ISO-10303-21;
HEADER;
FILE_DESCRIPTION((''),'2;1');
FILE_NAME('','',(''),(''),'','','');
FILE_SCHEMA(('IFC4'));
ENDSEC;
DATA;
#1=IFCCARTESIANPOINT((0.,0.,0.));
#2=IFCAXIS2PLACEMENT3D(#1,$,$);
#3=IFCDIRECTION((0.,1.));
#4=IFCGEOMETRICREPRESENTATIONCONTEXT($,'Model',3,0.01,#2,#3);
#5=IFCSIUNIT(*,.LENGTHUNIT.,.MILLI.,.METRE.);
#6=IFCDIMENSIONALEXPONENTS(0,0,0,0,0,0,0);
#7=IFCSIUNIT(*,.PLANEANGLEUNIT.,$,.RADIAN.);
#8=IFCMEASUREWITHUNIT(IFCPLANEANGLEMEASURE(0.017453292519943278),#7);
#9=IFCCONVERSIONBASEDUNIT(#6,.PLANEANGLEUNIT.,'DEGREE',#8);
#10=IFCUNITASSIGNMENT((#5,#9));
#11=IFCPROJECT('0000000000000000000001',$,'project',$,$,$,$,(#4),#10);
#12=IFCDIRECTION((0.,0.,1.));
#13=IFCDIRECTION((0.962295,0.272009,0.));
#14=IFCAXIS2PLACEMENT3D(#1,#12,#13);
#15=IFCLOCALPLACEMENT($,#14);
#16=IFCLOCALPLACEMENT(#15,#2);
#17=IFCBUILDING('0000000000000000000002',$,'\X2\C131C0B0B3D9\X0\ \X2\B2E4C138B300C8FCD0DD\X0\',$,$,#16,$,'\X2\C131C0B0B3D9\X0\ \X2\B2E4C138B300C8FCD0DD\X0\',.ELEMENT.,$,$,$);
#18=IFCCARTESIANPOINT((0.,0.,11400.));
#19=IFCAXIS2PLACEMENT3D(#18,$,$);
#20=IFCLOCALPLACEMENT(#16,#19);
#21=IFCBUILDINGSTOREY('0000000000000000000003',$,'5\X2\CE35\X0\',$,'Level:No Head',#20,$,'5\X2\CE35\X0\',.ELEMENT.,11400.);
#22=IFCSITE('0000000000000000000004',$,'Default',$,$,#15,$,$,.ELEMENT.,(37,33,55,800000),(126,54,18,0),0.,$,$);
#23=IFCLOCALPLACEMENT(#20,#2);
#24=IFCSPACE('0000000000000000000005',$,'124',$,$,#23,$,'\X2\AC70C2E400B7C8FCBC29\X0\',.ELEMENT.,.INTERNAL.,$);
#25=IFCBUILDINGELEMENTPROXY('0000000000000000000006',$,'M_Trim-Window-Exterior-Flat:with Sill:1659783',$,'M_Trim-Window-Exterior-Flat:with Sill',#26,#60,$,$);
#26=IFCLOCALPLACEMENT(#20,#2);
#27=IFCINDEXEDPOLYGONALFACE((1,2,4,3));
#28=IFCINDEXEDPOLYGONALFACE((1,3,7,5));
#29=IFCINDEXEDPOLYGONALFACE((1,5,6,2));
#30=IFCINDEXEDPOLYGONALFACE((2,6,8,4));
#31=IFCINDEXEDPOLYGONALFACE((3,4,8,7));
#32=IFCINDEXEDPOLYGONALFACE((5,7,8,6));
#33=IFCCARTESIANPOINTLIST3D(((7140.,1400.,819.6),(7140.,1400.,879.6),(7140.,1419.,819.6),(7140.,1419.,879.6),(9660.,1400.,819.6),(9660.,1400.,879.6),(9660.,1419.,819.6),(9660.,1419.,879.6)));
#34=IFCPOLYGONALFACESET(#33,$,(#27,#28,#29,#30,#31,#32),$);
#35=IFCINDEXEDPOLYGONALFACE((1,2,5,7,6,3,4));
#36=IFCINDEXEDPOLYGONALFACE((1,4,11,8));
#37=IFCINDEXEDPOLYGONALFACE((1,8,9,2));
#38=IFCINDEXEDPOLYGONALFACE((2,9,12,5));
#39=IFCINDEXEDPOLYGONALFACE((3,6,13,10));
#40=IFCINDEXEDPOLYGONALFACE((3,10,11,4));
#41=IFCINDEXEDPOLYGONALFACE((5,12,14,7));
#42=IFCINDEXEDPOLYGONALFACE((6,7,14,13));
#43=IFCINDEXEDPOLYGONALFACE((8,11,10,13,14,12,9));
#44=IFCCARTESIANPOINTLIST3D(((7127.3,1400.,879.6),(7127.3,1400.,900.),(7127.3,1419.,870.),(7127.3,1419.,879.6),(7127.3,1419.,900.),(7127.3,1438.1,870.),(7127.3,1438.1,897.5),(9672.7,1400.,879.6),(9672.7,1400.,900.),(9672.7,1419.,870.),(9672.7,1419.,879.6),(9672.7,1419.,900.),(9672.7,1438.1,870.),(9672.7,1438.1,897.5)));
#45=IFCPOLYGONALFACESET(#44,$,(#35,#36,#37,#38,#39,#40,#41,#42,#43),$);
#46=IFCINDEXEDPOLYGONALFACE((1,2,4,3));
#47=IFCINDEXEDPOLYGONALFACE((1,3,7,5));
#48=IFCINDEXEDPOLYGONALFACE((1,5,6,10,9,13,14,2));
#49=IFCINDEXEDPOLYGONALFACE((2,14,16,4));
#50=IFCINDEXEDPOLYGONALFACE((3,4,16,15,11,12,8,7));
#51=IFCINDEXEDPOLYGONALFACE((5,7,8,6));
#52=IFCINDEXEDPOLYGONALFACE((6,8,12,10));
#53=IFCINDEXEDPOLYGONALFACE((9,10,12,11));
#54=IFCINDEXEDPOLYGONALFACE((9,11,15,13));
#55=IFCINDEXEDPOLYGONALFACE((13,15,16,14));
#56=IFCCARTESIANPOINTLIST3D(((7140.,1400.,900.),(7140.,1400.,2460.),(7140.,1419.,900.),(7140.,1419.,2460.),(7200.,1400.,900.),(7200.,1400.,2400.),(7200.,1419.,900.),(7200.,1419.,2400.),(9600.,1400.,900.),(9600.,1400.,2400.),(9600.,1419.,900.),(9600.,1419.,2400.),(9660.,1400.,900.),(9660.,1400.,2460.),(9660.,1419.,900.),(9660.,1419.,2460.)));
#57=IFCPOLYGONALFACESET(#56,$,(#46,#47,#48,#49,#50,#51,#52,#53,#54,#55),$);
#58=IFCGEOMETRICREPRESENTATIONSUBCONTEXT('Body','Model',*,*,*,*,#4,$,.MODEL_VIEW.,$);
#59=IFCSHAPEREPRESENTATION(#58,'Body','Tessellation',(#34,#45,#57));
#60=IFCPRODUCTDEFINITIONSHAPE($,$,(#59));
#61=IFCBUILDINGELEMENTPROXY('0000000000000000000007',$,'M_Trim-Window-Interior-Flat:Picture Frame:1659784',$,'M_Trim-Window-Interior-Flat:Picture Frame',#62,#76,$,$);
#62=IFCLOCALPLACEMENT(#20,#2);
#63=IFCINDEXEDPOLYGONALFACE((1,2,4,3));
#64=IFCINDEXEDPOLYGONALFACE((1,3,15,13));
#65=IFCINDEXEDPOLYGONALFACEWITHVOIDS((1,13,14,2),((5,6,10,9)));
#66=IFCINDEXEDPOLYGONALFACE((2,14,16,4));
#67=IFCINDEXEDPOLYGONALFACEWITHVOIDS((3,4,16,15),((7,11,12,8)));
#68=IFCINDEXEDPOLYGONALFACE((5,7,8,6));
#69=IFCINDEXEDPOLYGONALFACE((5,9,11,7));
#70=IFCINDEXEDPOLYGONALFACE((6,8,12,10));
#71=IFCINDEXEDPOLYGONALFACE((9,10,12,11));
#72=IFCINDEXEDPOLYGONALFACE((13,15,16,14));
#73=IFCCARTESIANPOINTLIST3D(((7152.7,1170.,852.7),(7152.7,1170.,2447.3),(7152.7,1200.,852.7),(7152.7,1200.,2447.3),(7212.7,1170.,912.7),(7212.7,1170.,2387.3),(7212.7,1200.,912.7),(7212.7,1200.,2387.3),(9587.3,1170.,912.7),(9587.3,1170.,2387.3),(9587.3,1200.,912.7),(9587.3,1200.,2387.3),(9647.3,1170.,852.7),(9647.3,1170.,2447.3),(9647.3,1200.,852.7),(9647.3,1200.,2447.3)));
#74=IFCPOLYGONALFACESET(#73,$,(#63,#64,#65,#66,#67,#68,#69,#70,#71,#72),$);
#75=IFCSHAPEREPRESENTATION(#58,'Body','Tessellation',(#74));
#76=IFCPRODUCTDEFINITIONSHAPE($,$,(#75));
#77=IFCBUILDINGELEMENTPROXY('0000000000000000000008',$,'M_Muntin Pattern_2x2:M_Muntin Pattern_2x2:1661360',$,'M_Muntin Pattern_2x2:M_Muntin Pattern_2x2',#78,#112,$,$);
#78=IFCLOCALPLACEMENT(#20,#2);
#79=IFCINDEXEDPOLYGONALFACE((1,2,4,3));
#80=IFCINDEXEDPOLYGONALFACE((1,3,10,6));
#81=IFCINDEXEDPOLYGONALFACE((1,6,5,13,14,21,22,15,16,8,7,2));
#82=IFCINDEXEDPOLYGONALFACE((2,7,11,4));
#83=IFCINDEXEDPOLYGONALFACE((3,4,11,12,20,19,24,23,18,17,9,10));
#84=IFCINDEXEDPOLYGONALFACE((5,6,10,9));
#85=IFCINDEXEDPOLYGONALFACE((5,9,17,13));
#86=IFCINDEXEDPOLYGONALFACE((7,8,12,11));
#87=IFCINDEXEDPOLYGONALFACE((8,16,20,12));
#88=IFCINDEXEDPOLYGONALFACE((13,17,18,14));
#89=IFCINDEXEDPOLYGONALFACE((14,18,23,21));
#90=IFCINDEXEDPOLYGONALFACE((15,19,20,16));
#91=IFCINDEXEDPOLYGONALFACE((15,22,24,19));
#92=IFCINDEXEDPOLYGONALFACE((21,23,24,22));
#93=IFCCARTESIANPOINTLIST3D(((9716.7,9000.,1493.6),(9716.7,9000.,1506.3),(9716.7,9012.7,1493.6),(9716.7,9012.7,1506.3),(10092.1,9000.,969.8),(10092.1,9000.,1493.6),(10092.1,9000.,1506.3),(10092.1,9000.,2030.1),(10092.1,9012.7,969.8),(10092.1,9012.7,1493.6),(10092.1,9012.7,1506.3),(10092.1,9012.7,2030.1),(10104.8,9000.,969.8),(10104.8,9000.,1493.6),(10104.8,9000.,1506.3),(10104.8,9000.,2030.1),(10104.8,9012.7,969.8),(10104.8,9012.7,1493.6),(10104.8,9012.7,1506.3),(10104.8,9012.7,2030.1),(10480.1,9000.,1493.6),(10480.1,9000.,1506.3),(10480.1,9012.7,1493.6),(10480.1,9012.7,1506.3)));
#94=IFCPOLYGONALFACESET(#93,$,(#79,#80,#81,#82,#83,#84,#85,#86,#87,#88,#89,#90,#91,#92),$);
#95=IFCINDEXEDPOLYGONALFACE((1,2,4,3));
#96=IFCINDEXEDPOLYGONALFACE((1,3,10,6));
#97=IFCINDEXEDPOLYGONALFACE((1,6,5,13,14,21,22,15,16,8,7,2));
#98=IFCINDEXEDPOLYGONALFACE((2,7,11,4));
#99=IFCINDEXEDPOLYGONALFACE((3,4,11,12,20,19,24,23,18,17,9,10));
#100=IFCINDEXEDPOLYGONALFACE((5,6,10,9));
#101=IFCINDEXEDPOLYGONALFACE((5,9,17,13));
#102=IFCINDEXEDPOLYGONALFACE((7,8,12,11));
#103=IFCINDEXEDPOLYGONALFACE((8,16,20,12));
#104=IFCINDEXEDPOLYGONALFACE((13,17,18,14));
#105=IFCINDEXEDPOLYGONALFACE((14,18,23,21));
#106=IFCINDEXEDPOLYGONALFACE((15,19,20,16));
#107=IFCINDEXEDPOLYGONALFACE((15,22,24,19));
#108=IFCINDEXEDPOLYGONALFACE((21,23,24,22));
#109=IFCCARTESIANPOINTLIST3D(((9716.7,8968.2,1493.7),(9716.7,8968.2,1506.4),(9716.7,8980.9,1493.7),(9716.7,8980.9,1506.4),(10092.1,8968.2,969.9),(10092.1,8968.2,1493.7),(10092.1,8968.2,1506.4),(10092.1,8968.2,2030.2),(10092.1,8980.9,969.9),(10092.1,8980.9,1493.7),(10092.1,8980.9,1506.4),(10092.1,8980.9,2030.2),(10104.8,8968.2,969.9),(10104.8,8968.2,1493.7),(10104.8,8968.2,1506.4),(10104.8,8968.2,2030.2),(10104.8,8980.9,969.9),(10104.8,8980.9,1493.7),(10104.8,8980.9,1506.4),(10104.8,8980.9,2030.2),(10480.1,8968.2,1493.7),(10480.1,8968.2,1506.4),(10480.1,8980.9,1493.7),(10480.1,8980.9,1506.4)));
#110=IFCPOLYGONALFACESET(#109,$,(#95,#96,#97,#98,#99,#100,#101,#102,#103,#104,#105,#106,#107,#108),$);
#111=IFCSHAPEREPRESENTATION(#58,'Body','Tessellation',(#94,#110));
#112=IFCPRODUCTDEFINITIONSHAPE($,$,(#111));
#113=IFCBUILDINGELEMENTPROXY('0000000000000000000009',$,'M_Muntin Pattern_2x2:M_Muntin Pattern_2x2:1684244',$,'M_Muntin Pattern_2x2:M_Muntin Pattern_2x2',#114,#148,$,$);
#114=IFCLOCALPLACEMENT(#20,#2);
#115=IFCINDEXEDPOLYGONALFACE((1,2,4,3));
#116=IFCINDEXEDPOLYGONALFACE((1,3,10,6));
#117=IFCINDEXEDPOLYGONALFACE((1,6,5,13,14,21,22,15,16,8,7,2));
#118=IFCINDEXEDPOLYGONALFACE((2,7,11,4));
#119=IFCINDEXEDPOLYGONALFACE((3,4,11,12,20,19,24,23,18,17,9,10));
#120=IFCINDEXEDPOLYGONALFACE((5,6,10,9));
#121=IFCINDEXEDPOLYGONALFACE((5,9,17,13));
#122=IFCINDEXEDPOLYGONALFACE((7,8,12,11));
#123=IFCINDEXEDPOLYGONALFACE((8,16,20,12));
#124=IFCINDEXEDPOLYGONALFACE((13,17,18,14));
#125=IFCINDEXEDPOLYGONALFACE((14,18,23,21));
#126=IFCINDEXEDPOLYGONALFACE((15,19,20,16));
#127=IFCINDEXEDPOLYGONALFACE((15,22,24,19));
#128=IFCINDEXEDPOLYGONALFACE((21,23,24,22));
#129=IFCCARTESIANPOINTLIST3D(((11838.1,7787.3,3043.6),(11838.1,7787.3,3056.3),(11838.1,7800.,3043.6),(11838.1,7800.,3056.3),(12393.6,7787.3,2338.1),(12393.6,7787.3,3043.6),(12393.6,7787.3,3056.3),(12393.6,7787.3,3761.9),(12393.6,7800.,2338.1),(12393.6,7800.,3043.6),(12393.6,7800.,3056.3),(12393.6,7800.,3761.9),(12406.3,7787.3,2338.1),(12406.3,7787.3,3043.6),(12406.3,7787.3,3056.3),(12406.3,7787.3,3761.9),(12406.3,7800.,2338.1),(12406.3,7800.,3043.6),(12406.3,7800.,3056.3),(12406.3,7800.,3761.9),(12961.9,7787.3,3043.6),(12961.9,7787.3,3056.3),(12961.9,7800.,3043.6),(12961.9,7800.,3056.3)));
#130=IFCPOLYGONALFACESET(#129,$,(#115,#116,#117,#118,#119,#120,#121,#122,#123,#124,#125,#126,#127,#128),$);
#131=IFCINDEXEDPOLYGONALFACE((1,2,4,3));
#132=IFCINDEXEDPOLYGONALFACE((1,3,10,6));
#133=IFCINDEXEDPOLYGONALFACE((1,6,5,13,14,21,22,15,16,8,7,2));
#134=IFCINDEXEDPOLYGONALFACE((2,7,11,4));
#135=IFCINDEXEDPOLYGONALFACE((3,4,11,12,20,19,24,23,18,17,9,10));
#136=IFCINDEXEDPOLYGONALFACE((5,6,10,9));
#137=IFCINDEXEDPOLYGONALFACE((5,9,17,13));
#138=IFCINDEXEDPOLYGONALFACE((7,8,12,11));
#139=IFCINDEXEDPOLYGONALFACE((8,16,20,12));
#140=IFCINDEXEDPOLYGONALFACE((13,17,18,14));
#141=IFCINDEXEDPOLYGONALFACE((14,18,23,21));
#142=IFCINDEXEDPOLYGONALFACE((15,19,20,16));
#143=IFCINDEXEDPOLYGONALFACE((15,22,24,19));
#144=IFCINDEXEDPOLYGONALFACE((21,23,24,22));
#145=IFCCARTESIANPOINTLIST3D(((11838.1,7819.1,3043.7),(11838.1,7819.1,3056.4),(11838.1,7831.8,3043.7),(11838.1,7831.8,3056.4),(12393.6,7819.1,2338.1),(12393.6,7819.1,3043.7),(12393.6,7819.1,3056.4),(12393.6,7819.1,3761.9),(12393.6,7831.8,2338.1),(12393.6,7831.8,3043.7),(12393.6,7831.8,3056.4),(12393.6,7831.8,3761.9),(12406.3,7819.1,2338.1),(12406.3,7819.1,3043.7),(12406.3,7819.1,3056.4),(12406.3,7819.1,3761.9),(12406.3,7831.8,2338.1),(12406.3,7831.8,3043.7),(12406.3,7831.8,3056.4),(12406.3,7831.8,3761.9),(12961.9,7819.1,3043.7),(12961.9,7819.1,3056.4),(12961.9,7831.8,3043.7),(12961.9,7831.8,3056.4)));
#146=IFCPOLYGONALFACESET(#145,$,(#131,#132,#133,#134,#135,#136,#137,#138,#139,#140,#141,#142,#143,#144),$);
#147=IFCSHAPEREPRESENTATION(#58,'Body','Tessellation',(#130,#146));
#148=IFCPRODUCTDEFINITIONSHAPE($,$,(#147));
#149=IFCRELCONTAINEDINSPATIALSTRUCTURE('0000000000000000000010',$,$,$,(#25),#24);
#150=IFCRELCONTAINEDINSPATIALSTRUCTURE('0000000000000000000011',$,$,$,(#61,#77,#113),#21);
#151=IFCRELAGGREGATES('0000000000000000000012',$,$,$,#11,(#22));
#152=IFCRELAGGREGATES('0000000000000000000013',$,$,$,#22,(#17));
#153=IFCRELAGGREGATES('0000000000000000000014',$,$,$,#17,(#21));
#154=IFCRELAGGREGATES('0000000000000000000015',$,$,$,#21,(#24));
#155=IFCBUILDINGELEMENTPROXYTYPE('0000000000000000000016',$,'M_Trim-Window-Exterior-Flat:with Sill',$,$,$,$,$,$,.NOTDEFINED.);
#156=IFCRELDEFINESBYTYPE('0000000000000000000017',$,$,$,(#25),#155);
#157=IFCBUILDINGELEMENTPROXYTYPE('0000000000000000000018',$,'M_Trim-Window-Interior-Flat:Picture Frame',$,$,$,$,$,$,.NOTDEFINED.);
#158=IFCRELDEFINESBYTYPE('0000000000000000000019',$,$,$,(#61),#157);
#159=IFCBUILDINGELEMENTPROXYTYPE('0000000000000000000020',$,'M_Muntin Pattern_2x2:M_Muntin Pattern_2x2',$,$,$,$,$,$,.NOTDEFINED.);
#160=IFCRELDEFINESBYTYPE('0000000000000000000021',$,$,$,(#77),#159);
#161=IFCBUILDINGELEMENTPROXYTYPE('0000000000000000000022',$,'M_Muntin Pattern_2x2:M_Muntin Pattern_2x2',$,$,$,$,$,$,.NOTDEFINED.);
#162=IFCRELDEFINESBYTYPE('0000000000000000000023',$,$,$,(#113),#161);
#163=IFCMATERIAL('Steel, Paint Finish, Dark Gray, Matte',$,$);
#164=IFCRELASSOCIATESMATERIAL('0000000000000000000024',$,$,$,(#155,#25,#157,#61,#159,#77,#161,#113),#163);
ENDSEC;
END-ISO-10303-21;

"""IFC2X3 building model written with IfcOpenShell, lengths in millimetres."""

from ifc_helpers import new_model, entity, si_unit, converted_unit, direction, frame, frame_2d, origin, place, context, subcontext, project, spatial, polyline, rectangle, outline, extrude, source, transform, mapped, material, type_object, type_shapes, element, save


model = new_model("IFC2X3")

# Units and contexts
model_context = context("Model", 3, precision=0.01, world=origin(), true_north=direction((0.0, 1.0)))
body_context = subcontext(model_context, "Body", "Model", "MODEL_VIEW")
ifc_project = project(units=[si_unit("LENGTHUNIT", "METRE", prefix="MILLI"), converted_unit("PLANEANGLEUNIT", "DEGREE", entity("IfcPlaneAngleMeasure", 0.017453292519943278), si_unit("PLANEANGLEUNIT", "RADIAN"), dimensions=[0, 0, 0, 0, 0, 0, 0])], contexts=[model_context])

# Site, building, storey
site_placement = place(None, frame((0.0, 0.0, 0.0), z_axis=(0.0, 0.0, 1.0), x_axis=(0.962295, 0.272009, 0.0)))
site = spatial("IfcSite", under=ifc_project, at=site_placement, Name="Default", CompositionType="ELEMENT", RefLatitude=(37, 33, 55, 800000), RefLongitude=(126, 54, 18, 0), RefElevation=0.0)
building_placement = place(site_placement, origin())
building = spatial("IfcBuilding", under=site, at=building_placement, Name="성산동 다세대주택", LongName="성산동 다세대주택", CompositionType="ELEMENT")
storey_placement = place(building_placement, frame((0.0, 0.0, 11400.0)))
storey = spatial("IfcBuildingStorey", under=building, at=storey_placement, Name="5층", ObjectType="Level:No Head", LongName="5층", CompositionType="ELEMENT", Elevation=11400.0)

# Shared definitions
ifc_material_1 = material(Name="Steel, Paint Finish, Dark Gray, Matte")

# Shared definitions
space_1_placement = place(storey_placement, origin())
space_1 = spatial("IfcSpace", under=storey, at=space_1_placement, Name="124", LongName="거실·주방", CompositionType="ELEMENT", InteriorOrExteriorSpace="INTERNAL")

# Building element proxies
building_element_proxy_type_1 = type_object("IfcBuildingElementProxyType", Name="M_Trim-Window-Exterior-Flat:with Sill", PredefinedType="NOTDEFINED", material=ifc_material_1)
shared_shape_1 = source(origin(), body_context, "Body", "SweptSolid", [
    extrude(rectangle(XDim=2520.0, YDim=60.0, at=frame_2d((0.0, 0.0), x_axis=(1.0, 0.0))), frame((0.0, -1550.4, 0.0), z_axis=(0.0, 0.0, 1.0), x_axis=(-1.0, 0.0, 0.0)), (0.0, 0.0, 1.0), 19.0),
    extrude(outline(polyline([(-19.0, -15.2), (0.0, -15.2), (0.0, -5.7), (19.0, -5.7), (19.0, 14.8), (0.0, 14.8), (-19.0, 12.3), (-19.0, -15.2)])), frame((-1272.7, -1514.8, 19.0), z_axis=(1.0, 0.0, 0.0), x_axis=(0.0, 0.0, -1.0)), (0.0, 0.0, 1.0), 2545.4),
    extrude(outline(polyline([(-795.0, -1260.0), (765.0, -1260.0), (765.0, -1200.0), (-735.0, -1200.0), (-735.0, 1200.0), (765.0, 1200.0), (765.0, 1260.0), (-795.0, 1260.0), (-795.0, -1260.0)])), frame((0.0, -735.0, 0.0), z_axis=(0.0, 0.0, 1.0), x_axis=(0.0, -1.0, 0.0)), (0.0, 0.0, 1.0), 19.0),
])
type_shapes(building_element_proxy_type_1, [shared_shape_1])
proxy_1_placement = place(space_1_placement, frame((8400.0, 1400.0, 2400.0), z_axis=(0.0, 1.0, 0.0), x_axis=(-1.0, 0.0, 0.0)))
element("IfcBuildingElementProxy", 1, at=proxy_1_placement, inside=space_1, type_object=building_element_proxy_type_1, material=ifc_material_1, Name="M_Trim-Window-Exterior-Flat:with Sill:1659783", ObjectType="M_Trim-Window-Exterior-Flat:with Sill", context=body_context, shape_type="MappedRepresentation", body=[
    mapped(shared_shape_1, transform((0.0, 0.0, 0.0), scale=1.0)),
])
building_element_proxy_type_2 = type_object("IfcBuildingElementProxyType", Name="M_Trim-Window-Interior-Flat:Picture Frame", PredefinedType="NOTDEFINED", material=ifc_material_1)
shared_shape_2 = source(origin(), body_context, "Body", "SweptSolid", [
    extrude(outline(polyline([(-1247.3, -797.3), (1247.3, -797.3), (1247.3, 797.3), (-1247.3, 797.3), (-1247.3, -797.3)]), holes=[polyline([(-1187.3, -737.3), (-1187.3, 737.3), (1187.3, 737.3), (1187.3, -737.3), (-1187.3, -737.3)])]), frame((0.0, -750.0, 0.0), z_axis=(0.0, 0.0, 1.0), x_axis=(-1.0, 0.0, 0.0)), (0.0, 0.0, 1.0), 30.0),
])
type_shapes(building_element_proxy_type_2, [shared_shape_2])
proxy_2_placement = place(storey_placement, frame((8400.0, 1200.0, 2400.0), z_axis=(0.0, -1.0, 0.0), x_axis=(1.0, 0.0, 0.0)))
element("IfcBuildingElementProxy", 2, at=proxy_2_placement, inside=storey, type_object=building_element_proxy_type_2, material=ifc_material_1, Name="M_Trim-Window-Interior-Flat:Picture Frame:1659784", ObjectType="M_Trim-Window-Interior-Flat:Picture Frame", context=body_context, shape_type="MappedRepresentation", body=[
    mapped(shared_shape_2, transform((0.0, 0.0, 0.0), scale=1.0)),
])
building_element_proxy_type_3 = type_object("IfcBuildingElementProxyType", Name="M_Muntin Pattern_2x2:M_Muntin Pattern_2x2", PredefinedType="NOTDEFINED", material=ifc_material_1)
shared_shape_3 = source(origin(), body_context, "Body", "SweptSolid", [
    extrude(outline(polyline([(6.4, -6.4), (530.1, -6.4), (530.1, 6.3), (6.4, 6.3), (6.4, 381.7), (-6.3, 381.7), (-6.3, 6.3), (-530.2, 6.3), (-530.2, -6.4), (-6.3, -6.4), (-6.3, -381.7), (6.4, -381.7), (6.4, -6.4)])), frame((0.0, -22.2, 530.1), z_axis=(0.0, 1.0, 0.0), x_axis=(0.0, 0.0, 1.0)), (0.0, 0.0, 1.0), 12.7),
    extrude(outline(polyline([(6.4, -6.4), (530.2, -6.4), (530.2, 6.3), (6.4, 6.3), (6.4, 381.7), (-6.3, 381.7), (-6.3, 6.3), (-530.2, 6.3), (-530.2, -6.4), (-6.3, -6.4), (-6.3, -381.7), (6.4, -381.7), (6.4, -6.4)])), frame((0.0, 9.5, 530.2), z_axis=(0.0, 1.0, 0.0), x_axis=(0.0, 0.0, 1.0)), (0.0, 0.0, 1.0), 12.7),
])
type_shapes(building_element_proxy_type_3, [shared_shape_3])
proxy_3_placement = place(storey_placement, frame((10098.4, 8990.5, 969.9), z_axis=(0.0, 0.0, 1.0), x_axis=(-1.0, 0.0, 0.0)))
element("IfcBuildingElementProxy", 3, at=proxy_3_placement, inside=storey, type_object=building_element_proxy_type_3, material=ifc_material_1, Name="M_Muntin Pattern_2x2:M_Muntin Pattern_2x2:1661360", ObjectType="M_Muntin Pattern_2x2:M_Muntin Pattern_2x2", context=body_context, shape_type="MappedRepresentation", body=[
    mapped(shared_shape_3, transform((0.0, 0.0, 0.0), scale=1.0)),
])
building_element_proxy_type_4 = type_object("IfcBuildingElementProxyType", Name="M_Muntin Pattern_2x2:M_Muntin Pattern_2x2", PredefinedType="NOTDEFINED", material=ifc_material_1)
shared_shape_4 = source(origin(), body_context, "Body", "SweptSolid", [
    extrude(outline(polyline([(6.4, -6.4), (711.9, -6.4), (711.9, 6.3), (6.4, 6.3), (6.4, 561.9), (-6.3, 561.9), (-6.3, 6.3), (-711.9, 6.3), (-711.9, -6.4), (-6.3, -6.4), (-6.3, -561.9), (6.4, -561.9), (6.4, -6.4)])), frame((0.0, -22.2, 711.9), z_axis=(0.0, 1.0, 0.0), x_axis=(0.0, 0.0, 1.0)), (0.0, 0.0, 1.0), 12.7),
    extrude(outline(polyline([(6.4, -6.4), (711.9, -6.4), (711.9, 6.3), (6.4, 6.3), (6.4, 561.9), (-6.3, 561.9), (-6.3, 6.3), (-711.9, 6.3), (-711.9, -6.4), (-6.3, -6.4), (-6.3, -561.9), (6.4, -561.9), (6.4, -6.4)])), frame((0.0, 9.5, 711.9), z_axis=(0.0, 1.0, 0.0), x_axis=(0.0, 0.0, 1.0)), (0.0, 0.0, 1.0), 12.7),
])
type_shapes(building_element_proxy_type_4, [shared_shape_4])
proxy_4_placement = place(storey_placement, frame((12400.0, 7809.5, 2338.1)))
element("IfcBuildingElementProxy", 4, at=proxy_4_placement, inside=storey, type_object=building_element_proxy_type_4, material=ifc_material_1, Name="M_Muntin Pattern_2x2:M_Muntin Pattern_2x2:1684244", ObjectType="M_Muntin Pattern_2x2:M_Muntin Pattern_2x2", context=body_context, shape_type="MappedRepresentation", body=[
    mapped(shared_shape_4, transform((0.0, 0.0, 0.0), scale=1.0)),
])

save(model, "model.ifc")
